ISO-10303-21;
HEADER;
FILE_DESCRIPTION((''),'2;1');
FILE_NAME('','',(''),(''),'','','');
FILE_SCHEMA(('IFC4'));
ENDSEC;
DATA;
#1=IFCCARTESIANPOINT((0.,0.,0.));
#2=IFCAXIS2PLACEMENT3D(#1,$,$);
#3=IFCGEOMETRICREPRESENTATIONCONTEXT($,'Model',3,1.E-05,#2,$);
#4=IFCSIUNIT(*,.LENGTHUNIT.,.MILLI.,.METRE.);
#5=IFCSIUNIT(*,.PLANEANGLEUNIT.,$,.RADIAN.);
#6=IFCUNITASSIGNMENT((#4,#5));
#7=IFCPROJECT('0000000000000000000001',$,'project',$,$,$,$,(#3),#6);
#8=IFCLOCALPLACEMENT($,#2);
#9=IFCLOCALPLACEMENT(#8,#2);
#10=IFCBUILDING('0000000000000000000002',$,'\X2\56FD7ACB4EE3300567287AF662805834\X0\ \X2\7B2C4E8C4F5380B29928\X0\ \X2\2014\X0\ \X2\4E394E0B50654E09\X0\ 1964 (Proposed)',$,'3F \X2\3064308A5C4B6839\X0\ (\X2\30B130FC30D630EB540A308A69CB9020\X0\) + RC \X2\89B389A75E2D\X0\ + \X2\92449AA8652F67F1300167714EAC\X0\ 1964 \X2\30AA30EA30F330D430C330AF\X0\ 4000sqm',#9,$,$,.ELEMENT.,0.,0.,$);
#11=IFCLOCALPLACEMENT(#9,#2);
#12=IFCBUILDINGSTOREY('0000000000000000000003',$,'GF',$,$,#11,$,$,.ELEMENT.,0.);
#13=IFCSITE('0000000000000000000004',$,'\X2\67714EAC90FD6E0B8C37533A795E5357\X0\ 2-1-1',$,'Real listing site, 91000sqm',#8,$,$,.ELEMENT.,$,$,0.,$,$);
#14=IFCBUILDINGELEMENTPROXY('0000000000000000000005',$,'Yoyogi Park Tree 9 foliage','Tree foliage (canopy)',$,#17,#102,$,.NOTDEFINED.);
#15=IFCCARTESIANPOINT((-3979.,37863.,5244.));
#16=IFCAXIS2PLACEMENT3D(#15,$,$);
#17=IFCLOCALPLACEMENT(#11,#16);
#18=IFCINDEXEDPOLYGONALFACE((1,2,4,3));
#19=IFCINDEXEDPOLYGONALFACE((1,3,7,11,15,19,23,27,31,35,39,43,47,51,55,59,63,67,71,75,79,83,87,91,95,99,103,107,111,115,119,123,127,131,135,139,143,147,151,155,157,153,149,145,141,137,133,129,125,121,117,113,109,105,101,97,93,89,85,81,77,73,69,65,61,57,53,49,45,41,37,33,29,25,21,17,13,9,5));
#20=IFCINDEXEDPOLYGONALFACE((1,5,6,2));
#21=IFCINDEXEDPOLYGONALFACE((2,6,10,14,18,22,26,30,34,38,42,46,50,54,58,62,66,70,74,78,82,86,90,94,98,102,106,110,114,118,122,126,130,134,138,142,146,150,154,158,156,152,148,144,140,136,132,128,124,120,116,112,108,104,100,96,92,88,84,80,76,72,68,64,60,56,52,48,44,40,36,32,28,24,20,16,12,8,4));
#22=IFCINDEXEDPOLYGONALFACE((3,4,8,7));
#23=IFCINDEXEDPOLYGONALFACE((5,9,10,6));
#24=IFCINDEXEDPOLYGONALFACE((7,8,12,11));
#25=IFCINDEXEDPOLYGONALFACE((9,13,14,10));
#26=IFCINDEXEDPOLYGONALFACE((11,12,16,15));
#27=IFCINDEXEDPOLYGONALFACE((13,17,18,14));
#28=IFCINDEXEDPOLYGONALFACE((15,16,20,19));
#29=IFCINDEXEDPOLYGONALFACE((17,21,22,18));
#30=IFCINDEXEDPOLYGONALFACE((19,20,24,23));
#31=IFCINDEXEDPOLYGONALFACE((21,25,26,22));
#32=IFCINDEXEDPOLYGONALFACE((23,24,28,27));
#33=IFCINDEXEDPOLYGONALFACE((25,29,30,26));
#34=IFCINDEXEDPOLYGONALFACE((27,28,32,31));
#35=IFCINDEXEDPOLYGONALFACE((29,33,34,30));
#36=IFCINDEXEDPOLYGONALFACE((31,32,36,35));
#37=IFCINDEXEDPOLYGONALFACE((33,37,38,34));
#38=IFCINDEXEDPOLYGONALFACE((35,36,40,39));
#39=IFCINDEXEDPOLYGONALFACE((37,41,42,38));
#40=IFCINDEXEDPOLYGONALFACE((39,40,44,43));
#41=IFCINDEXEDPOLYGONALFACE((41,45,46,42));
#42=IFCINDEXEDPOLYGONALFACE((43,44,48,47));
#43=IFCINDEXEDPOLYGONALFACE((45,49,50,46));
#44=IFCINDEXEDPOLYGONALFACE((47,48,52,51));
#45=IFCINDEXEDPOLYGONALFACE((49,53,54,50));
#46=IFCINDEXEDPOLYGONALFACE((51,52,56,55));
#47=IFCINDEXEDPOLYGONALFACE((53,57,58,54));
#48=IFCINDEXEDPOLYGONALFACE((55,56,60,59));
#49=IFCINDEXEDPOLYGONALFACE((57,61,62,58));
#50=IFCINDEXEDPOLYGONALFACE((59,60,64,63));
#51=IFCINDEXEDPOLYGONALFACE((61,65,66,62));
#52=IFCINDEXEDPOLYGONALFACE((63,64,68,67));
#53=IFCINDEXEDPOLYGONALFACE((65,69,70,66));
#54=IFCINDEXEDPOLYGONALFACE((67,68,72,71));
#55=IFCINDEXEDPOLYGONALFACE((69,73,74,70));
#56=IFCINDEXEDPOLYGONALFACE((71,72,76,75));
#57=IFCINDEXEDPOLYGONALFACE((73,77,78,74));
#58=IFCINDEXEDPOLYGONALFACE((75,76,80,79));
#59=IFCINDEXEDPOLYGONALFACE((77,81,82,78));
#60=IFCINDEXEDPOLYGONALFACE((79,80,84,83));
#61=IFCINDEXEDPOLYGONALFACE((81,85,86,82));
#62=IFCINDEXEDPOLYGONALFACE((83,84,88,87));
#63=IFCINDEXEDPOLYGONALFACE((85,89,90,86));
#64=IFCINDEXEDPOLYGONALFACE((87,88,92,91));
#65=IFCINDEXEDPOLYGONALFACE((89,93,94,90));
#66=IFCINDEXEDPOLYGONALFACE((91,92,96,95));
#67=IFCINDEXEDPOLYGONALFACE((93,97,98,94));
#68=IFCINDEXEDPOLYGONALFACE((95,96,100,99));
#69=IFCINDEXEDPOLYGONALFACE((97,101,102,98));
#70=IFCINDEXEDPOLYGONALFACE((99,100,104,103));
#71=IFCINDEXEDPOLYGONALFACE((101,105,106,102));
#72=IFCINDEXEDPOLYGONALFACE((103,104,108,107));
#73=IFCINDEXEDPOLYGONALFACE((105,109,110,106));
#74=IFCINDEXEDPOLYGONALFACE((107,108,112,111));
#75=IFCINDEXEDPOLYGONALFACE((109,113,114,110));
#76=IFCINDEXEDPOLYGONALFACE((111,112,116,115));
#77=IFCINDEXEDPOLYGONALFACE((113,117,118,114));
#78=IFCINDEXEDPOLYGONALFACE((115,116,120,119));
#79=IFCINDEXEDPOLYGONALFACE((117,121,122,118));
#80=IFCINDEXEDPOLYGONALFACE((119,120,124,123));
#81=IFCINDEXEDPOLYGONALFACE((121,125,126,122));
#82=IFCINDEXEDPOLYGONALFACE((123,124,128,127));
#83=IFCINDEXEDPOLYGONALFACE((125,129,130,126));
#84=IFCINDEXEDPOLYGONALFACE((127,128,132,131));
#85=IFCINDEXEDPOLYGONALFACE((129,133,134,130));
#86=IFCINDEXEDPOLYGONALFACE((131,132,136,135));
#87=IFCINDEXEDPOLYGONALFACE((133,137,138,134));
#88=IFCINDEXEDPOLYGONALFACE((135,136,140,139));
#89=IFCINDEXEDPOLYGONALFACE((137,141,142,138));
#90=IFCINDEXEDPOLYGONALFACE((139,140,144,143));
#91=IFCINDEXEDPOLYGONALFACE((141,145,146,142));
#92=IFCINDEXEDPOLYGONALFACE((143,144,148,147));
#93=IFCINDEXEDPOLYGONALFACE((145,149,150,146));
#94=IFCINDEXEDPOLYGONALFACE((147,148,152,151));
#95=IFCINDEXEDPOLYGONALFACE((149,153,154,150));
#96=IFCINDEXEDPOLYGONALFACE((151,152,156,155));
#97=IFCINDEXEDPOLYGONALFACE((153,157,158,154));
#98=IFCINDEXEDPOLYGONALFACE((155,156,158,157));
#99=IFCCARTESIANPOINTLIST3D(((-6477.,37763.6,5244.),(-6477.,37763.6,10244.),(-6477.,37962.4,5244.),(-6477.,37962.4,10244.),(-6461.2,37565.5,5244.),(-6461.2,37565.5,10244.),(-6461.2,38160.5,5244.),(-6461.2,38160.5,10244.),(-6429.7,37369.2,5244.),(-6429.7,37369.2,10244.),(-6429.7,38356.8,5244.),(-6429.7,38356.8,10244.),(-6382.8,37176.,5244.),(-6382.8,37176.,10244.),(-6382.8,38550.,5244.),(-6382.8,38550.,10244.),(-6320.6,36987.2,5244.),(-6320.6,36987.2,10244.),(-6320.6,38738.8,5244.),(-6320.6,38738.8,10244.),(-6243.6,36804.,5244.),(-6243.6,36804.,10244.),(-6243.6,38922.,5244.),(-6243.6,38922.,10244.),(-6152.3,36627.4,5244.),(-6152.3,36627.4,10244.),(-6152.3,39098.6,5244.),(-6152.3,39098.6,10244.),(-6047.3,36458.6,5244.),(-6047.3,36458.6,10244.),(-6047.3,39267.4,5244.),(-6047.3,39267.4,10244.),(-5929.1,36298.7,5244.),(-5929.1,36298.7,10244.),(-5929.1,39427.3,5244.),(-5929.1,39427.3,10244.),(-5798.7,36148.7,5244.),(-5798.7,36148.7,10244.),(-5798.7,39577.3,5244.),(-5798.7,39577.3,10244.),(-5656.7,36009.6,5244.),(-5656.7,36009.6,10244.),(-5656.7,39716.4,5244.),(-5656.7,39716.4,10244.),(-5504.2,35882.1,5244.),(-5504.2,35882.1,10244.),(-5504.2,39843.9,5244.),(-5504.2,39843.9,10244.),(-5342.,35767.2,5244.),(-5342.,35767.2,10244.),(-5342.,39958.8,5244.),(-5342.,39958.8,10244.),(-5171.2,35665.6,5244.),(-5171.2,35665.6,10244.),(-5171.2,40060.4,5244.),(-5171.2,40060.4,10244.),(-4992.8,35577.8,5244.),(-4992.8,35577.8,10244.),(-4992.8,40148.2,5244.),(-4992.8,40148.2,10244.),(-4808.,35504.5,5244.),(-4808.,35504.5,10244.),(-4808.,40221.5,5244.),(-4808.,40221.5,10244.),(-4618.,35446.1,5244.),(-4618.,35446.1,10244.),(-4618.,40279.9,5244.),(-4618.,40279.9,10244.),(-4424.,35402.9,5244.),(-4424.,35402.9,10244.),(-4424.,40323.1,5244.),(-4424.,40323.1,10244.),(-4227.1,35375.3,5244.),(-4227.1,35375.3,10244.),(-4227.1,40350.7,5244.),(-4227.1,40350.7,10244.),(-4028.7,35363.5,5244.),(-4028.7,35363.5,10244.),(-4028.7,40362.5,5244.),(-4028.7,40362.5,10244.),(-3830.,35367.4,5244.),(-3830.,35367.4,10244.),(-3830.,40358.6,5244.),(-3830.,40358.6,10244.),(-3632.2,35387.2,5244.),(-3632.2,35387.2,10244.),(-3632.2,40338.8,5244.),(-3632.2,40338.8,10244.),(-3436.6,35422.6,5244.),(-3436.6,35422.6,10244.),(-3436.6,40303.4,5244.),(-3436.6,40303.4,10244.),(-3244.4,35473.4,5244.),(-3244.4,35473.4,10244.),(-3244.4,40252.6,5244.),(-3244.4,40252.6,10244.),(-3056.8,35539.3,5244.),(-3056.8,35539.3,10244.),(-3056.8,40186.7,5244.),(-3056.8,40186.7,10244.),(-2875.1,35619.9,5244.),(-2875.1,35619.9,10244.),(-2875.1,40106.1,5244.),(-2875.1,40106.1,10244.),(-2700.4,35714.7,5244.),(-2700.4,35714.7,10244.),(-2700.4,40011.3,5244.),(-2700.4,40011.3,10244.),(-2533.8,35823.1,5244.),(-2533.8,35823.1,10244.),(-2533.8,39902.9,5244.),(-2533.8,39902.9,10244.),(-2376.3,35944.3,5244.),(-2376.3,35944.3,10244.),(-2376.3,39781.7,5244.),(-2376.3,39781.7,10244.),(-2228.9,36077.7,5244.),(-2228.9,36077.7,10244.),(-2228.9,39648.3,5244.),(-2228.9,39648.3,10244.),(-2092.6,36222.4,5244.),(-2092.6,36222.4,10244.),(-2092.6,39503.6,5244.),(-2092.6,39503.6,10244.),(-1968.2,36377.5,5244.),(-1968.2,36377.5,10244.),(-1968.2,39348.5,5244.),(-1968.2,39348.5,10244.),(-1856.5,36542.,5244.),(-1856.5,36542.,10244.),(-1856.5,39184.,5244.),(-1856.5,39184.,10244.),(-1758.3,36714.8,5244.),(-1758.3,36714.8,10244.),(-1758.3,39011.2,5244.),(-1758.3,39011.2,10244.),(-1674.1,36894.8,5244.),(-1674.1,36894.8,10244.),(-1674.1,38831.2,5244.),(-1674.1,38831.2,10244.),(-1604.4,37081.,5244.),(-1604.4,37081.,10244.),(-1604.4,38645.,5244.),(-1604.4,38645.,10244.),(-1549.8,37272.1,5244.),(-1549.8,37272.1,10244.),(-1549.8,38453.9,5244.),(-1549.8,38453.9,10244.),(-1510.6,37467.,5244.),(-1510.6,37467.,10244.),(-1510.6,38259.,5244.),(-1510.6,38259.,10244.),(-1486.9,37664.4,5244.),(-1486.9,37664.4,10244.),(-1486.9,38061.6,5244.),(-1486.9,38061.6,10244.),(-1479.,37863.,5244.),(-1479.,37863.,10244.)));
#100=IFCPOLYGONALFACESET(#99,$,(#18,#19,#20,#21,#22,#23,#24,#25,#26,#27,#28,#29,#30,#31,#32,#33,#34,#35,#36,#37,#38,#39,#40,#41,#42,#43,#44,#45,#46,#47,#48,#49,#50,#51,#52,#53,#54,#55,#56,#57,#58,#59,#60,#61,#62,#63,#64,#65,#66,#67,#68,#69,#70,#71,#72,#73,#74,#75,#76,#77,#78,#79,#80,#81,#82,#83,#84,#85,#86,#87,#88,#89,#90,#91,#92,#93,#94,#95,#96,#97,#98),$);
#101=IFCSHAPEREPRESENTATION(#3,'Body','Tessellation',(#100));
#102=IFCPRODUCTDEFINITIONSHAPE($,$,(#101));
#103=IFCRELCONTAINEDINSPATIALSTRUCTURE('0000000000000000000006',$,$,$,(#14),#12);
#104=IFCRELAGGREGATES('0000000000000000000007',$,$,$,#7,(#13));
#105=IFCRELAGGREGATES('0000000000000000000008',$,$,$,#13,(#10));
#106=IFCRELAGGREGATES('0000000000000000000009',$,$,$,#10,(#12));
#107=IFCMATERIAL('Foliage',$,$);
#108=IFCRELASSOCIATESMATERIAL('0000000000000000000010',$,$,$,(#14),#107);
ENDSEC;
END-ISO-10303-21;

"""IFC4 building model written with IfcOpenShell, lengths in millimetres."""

from ifc_helpers import new_model, si_unit, frame, origin, origin_2d, place, context, project, spatial, circle, extrude, material, element, save


model = new_model("IFC4")

# Units and contexts
model_context = context("Model", 3, precision=1e-05, world=origin())
ifc_project = project(units=[si_unit("LENGTHUNIT", "METRE", prefix="MILLI"), si_unit("PLANEANGLEUNIT", "RADIAN")], contexts=[model_context])

# Site, building, storey
site_placement = place(None, origin())
site = spatial("IfcSite", under=ifc_project, at=site_placement, Name="東京都渋谷区神南 2-1-1", ObjectType="Real listing site, 91000sqm", CompositionType="ELEMENT", RefElevation=0.0)
building_placement = place(site_placement, origin())
building = spatial("IfcBuilding", under=site, at=building_placement, Name="国立代々木競技場 第二体育館 — 丹下健三 1964 (Proposed)", ObjectType="3F つり屋根 (ケーブル吊り構造) + RC 観覧席 + 鉄骨支柱、東京 1964 オリンピック 4000sqm", CompositionType="ELEMENT", ElevationOfRefHeight=0.0, ElevationOfTerrain=0.0)
storey_placement = place(building_placement, origin())
storey = spatial("IfcBuildingStorey", under=building, at=storey_placement, Name="GF", CompositionType="ELEMENT", Elevation=0.0)

# Building element proxy
ifc_material_1 = material(Name="Foliage")
proxy_1_placement = place(storey_placement, frame((-3979.0, 37863.0, 5244.0)))
element("IfcBuildingElementProxy", 1, at=proxy_1_placement, inside=storey, material=ifc_material_1, Name="Yoyogi Park Tree 9 foliage", Description="Tree foliage (canopy)", PredefinedType="NOTDEFINED", context=model_context, shape_type="SweptSolid", body=[
    extrude(circle(Radius=2500.0, at=origin_2d()), frame((-3979.0, 37863.0, 5244.0)), (0.0, 0.0, 1.0), 5000.0),
])

save(model, "model.ifc")
